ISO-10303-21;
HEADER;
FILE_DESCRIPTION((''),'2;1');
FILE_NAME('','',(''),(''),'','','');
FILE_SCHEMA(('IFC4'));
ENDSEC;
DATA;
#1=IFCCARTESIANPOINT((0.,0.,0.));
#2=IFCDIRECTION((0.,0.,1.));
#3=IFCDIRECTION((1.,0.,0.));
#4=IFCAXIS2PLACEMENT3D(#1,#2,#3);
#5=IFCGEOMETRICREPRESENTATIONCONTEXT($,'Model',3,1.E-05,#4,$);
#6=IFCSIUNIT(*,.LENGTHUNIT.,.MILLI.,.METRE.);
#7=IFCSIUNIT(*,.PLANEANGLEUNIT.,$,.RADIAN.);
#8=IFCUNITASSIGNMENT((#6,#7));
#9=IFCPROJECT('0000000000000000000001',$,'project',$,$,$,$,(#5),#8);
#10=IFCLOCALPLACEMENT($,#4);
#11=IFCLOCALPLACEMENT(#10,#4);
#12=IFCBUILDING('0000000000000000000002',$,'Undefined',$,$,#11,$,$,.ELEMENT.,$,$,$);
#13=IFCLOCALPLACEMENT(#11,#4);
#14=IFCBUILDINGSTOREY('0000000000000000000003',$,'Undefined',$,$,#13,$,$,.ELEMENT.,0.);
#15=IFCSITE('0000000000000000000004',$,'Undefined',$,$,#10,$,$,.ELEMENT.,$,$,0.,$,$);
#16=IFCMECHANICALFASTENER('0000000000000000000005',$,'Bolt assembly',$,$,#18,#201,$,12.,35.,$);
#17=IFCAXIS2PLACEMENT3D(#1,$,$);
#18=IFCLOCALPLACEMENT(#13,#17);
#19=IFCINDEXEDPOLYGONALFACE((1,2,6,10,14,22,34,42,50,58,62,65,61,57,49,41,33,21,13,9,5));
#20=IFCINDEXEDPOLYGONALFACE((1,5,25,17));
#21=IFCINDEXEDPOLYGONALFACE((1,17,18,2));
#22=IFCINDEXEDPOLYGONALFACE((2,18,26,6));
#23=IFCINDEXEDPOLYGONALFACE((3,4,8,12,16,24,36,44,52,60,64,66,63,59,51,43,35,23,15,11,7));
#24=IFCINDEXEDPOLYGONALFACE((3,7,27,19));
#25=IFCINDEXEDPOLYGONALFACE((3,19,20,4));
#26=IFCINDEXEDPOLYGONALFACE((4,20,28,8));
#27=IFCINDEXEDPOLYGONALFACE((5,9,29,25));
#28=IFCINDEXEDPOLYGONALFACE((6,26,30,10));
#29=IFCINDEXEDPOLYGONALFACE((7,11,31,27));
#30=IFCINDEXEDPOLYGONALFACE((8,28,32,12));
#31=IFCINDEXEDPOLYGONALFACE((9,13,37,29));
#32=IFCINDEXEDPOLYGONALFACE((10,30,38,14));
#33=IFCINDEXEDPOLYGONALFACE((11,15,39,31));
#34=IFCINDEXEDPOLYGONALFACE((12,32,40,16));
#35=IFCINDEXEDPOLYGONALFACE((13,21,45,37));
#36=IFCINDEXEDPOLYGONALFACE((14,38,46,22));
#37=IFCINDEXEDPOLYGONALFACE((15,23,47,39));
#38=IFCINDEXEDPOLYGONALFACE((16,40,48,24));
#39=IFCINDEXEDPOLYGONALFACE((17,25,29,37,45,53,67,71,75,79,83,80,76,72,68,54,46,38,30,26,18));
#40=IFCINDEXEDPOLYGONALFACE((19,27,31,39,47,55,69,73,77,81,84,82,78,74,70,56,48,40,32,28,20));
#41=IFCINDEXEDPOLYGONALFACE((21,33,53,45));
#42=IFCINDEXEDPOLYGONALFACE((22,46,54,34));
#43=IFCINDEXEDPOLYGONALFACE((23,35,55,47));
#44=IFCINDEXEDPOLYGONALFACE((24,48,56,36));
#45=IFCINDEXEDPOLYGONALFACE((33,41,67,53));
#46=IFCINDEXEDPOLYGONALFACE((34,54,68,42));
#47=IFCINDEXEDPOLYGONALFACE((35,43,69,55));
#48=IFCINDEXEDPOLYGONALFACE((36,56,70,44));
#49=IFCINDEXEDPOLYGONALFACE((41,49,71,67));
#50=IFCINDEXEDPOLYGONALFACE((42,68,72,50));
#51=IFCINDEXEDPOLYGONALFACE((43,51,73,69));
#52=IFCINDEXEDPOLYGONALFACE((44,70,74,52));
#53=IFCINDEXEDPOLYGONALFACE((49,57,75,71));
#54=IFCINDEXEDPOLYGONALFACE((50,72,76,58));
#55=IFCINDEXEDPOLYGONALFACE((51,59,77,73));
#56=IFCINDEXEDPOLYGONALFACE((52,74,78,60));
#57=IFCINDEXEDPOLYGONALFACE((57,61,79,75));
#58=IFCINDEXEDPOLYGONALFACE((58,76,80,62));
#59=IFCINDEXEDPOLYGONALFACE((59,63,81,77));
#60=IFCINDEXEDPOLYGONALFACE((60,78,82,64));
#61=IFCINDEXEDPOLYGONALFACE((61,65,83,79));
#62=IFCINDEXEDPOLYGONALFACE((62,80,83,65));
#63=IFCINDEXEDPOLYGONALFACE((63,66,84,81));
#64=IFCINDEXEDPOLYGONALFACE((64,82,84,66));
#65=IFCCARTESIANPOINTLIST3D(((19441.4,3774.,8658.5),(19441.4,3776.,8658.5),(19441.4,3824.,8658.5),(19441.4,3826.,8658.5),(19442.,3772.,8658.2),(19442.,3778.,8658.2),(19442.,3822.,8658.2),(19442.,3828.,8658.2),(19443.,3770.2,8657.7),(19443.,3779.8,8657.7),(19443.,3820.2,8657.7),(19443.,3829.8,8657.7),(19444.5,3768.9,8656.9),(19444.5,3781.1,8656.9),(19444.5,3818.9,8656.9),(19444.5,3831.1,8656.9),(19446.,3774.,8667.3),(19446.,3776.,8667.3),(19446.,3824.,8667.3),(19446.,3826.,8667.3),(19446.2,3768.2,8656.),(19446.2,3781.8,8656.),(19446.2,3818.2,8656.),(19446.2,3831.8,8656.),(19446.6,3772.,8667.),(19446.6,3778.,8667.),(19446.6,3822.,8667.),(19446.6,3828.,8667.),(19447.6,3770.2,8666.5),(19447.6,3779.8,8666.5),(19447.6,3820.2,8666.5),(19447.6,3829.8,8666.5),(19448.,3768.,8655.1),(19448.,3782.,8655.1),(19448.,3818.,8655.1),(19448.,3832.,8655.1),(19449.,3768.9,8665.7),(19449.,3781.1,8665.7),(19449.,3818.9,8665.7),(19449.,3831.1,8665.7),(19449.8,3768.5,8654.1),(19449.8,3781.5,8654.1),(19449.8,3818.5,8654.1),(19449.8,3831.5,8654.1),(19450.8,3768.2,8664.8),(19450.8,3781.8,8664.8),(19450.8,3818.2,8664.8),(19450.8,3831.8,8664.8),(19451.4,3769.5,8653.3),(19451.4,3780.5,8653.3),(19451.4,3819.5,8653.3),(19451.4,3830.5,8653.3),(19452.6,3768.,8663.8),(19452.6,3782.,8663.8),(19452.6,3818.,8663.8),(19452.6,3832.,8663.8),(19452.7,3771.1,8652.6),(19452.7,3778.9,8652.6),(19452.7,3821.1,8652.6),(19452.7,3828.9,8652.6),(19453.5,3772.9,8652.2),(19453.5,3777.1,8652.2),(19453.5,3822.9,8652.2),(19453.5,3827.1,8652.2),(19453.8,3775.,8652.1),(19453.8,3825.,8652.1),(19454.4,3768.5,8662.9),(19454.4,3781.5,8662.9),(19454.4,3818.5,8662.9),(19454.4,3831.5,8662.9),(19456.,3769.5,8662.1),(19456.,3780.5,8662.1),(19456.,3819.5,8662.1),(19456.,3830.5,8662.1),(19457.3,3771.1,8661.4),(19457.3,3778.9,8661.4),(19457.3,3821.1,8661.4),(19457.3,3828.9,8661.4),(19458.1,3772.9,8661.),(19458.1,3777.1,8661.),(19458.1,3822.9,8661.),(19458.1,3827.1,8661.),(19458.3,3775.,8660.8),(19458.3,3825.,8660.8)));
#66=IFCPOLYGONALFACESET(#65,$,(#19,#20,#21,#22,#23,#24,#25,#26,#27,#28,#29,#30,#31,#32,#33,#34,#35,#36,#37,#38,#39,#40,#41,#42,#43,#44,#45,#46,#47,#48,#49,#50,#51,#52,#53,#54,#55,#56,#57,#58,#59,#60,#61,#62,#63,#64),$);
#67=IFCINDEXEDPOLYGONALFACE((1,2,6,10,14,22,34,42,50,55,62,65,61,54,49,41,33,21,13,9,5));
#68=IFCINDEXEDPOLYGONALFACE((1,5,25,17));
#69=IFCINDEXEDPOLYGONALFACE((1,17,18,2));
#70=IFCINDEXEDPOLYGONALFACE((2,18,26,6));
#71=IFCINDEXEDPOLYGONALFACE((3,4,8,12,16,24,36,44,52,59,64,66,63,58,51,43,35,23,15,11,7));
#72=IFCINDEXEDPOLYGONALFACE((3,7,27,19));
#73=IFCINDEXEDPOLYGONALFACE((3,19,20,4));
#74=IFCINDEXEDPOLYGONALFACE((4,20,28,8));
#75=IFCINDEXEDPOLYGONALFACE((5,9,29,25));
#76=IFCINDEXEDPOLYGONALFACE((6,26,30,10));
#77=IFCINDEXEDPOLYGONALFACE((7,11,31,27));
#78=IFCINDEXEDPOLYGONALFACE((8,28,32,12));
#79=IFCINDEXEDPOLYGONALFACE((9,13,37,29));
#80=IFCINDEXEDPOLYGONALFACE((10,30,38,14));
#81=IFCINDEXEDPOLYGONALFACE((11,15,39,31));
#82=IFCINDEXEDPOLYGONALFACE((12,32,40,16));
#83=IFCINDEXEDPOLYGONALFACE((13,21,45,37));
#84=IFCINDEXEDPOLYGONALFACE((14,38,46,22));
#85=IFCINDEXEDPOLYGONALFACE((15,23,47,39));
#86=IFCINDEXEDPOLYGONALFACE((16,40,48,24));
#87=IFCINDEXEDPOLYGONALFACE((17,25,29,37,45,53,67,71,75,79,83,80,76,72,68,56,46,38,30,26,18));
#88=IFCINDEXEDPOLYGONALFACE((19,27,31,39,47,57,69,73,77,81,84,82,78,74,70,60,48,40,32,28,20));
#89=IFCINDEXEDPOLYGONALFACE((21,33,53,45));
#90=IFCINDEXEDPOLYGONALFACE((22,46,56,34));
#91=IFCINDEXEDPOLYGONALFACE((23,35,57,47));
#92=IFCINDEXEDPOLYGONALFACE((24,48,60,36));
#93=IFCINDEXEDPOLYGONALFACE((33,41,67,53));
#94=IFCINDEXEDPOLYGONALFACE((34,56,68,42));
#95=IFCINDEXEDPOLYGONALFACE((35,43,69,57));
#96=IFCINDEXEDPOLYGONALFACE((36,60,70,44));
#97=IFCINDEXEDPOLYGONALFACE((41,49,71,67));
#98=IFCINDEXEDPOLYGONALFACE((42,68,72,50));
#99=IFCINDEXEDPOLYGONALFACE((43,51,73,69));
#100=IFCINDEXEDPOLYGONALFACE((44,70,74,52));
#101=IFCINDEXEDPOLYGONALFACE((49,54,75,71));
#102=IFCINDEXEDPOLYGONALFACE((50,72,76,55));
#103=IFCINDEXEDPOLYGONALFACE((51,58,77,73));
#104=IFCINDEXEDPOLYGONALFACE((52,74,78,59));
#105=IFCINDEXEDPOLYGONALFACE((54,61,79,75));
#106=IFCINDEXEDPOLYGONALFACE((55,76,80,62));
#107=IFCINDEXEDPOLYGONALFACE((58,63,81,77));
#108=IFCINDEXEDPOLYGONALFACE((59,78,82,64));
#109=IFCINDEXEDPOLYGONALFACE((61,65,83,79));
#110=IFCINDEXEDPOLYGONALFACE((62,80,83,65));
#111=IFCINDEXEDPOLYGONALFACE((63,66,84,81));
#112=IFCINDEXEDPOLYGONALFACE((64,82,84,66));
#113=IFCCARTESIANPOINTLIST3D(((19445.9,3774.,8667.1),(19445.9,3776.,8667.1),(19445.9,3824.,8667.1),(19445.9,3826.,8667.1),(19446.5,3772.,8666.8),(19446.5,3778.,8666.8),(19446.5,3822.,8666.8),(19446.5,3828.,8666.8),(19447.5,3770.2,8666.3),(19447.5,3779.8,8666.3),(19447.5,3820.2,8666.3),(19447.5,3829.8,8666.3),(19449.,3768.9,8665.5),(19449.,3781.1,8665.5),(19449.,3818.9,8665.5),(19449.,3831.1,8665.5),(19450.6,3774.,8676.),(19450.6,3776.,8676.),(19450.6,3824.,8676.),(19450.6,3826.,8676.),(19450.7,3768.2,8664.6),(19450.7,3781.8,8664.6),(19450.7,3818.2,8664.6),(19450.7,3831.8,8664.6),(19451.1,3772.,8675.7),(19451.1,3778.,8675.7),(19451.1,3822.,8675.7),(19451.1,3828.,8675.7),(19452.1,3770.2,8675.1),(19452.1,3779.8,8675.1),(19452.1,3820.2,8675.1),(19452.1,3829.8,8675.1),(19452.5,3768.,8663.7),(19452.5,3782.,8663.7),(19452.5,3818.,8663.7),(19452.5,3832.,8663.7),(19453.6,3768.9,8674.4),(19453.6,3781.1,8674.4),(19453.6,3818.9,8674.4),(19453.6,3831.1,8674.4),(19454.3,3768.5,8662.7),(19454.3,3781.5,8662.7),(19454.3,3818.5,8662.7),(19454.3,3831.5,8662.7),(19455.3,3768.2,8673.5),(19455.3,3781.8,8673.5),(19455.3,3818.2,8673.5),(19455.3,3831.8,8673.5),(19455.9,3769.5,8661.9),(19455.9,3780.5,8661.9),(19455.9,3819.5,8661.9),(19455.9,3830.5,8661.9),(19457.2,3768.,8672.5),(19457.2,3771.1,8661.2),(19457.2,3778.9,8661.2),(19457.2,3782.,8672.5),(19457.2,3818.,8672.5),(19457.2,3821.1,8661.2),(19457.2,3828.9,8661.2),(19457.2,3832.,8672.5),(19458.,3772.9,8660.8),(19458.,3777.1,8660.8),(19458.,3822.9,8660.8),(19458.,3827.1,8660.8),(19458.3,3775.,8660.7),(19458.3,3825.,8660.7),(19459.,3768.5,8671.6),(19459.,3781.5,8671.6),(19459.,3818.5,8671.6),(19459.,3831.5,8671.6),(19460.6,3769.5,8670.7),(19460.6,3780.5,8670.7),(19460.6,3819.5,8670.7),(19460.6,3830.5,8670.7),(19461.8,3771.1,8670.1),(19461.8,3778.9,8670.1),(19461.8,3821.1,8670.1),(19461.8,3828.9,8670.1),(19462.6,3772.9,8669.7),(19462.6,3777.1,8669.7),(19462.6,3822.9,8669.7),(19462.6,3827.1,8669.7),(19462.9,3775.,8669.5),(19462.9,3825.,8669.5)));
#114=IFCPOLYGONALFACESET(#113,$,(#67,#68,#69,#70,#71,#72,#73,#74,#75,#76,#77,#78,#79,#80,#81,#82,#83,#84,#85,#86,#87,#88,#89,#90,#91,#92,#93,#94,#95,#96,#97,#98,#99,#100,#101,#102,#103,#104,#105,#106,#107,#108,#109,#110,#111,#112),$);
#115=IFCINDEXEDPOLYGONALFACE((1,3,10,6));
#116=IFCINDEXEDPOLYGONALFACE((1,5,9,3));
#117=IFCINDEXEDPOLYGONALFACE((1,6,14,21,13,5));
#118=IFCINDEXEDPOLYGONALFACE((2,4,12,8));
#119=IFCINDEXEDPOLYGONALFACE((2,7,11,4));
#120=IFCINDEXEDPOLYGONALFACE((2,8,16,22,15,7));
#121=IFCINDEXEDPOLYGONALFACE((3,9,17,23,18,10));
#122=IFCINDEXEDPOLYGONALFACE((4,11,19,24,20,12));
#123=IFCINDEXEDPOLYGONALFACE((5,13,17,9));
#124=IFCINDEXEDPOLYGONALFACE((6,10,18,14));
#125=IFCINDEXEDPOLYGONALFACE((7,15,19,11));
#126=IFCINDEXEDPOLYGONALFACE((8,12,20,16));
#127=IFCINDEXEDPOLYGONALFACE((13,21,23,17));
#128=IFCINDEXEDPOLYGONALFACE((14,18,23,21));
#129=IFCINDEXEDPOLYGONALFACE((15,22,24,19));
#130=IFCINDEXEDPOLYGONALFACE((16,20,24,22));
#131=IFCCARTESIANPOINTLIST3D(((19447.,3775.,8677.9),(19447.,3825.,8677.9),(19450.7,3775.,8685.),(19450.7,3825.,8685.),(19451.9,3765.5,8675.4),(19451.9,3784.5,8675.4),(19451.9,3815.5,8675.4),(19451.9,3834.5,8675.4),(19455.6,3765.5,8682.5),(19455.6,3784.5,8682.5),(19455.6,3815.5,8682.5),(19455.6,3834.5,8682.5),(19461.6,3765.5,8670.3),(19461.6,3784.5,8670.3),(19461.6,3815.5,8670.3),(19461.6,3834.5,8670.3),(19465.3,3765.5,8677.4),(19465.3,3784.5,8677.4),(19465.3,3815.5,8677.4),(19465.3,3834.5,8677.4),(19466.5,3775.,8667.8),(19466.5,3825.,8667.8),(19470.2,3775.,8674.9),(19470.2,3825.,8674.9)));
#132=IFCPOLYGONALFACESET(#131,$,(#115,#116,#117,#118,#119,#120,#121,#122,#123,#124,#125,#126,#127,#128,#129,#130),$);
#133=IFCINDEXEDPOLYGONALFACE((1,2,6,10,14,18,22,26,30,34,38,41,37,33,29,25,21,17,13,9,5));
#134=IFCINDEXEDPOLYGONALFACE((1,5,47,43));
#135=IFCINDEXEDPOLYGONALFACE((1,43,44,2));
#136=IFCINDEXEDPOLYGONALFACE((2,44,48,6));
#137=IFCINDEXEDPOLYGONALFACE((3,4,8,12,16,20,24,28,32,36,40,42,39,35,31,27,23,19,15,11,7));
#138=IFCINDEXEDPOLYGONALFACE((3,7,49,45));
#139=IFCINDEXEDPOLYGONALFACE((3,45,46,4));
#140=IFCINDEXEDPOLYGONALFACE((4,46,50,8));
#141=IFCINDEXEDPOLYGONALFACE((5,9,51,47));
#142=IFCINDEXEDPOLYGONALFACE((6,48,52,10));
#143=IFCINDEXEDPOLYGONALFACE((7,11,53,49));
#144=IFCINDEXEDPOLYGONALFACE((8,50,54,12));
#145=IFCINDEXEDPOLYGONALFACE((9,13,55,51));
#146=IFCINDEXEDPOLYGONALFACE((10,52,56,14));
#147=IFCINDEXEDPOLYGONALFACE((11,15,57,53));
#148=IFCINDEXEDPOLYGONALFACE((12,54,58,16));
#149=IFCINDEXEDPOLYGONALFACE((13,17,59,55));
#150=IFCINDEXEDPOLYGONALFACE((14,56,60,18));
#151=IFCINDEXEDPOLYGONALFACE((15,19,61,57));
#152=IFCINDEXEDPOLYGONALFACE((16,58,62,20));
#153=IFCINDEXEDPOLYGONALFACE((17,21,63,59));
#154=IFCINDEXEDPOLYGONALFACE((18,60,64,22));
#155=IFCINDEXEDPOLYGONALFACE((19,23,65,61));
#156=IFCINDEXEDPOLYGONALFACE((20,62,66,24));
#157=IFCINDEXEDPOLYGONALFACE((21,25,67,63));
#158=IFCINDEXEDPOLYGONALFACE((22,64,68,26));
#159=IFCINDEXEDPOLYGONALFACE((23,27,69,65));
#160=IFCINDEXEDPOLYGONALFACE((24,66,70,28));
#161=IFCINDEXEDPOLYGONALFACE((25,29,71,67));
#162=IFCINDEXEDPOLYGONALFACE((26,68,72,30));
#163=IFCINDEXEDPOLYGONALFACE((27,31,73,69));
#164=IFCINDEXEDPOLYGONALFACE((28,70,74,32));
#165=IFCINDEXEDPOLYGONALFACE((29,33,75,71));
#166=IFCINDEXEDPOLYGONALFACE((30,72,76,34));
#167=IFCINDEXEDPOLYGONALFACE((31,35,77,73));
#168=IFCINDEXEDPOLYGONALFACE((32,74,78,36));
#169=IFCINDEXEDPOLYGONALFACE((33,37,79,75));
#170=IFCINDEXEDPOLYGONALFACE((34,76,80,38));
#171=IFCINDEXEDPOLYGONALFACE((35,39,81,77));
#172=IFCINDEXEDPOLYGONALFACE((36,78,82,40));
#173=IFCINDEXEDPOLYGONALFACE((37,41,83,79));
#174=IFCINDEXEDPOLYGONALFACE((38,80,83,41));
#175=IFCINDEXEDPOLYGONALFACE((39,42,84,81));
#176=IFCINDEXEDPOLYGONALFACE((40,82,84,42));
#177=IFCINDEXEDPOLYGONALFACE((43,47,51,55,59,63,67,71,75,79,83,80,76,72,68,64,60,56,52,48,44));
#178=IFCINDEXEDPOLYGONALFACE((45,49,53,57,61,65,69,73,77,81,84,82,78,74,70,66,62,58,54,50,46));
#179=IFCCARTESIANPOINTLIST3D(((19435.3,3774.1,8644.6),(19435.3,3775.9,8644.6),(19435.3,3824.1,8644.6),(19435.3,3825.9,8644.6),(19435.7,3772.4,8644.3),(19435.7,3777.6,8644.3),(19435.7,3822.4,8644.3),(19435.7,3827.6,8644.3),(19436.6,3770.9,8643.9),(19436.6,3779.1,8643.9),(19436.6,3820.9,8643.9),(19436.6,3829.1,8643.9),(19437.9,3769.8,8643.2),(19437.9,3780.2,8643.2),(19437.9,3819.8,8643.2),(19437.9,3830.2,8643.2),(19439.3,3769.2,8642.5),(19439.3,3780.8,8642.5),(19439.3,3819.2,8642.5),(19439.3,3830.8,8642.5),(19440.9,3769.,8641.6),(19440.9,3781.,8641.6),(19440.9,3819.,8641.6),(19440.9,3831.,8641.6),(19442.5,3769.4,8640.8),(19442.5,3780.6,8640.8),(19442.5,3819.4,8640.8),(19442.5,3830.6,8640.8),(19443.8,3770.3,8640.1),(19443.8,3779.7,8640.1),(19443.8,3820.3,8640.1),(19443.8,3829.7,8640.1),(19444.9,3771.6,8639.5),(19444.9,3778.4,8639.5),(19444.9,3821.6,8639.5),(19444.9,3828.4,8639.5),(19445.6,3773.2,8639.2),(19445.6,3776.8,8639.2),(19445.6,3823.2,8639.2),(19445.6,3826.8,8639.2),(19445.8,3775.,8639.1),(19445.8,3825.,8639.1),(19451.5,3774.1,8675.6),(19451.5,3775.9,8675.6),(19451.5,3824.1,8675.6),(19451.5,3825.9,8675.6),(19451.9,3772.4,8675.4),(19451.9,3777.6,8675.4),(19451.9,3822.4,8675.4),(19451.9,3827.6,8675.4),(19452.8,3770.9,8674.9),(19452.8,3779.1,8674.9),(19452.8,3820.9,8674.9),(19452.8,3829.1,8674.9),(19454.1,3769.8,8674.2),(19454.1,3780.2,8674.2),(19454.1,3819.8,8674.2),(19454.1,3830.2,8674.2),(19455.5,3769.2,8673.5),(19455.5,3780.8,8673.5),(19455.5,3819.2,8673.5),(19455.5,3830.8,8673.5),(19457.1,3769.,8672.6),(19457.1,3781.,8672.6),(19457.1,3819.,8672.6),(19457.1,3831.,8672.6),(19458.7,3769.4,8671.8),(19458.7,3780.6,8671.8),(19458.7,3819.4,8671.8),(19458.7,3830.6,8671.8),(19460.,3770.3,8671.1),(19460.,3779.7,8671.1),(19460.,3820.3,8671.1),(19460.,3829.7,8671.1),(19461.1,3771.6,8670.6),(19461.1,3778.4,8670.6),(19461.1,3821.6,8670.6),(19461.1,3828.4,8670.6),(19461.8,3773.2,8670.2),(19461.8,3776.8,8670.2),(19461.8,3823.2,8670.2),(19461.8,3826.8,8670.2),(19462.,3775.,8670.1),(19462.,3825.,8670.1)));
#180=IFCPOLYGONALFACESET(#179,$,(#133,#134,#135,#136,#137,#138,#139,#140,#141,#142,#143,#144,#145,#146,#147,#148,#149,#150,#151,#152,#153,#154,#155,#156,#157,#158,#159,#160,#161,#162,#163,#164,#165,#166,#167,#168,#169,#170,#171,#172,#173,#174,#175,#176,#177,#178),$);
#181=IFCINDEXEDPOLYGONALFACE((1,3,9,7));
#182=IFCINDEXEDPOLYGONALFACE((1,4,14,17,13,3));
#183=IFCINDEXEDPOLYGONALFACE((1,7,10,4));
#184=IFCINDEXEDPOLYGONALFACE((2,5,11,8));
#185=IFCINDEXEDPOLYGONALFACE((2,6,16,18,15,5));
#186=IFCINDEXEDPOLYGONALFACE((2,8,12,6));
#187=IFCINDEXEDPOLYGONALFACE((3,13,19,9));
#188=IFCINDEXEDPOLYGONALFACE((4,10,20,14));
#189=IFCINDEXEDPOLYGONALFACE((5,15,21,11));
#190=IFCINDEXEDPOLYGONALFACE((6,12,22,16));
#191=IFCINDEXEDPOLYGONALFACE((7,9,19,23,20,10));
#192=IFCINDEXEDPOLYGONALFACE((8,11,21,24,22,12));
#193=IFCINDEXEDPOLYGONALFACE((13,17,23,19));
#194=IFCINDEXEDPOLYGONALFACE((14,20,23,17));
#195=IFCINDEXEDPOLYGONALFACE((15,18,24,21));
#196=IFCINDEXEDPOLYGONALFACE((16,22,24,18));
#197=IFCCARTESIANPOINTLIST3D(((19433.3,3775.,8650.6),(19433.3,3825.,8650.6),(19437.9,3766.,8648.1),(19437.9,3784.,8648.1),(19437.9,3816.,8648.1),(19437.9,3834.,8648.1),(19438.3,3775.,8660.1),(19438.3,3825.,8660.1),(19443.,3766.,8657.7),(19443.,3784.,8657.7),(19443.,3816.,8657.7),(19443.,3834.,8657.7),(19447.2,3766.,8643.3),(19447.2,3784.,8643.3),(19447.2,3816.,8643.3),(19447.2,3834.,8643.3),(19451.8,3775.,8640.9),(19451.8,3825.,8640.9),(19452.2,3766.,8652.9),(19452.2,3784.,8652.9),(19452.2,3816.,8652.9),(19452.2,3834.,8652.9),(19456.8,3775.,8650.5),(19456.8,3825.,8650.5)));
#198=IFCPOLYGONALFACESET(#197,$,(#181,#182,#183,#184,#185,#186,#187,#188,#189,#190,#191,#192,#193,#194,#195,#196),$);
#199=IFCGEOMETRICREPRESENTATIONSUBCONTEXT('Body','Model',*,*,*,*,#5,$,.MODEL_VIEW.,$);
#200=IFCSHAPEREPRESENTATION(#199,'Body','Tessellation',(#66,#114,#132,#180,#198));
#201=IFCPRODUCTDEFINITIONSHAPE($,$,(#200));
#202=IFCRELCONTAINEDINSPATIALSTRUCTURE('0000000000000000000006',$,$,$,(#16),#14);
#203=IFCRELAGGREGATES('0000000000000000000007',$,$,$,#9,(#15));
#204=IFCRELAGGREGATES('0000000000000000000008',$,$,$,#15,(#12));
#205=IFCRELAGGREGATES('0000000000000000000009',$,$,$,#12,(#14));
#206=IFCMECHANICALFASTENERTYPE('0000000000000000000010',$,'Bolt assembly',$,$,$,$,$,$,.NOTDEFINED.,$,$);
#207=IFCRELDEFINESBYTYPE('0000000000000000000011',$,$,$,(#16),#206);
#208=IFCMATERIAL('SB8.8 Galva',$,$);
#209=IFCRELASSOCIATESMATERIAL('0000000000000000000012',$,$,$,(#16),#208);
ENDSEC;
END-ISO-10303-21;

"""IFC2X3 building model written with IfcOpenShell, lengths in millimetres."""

from ifc_helpers import new_model, si_unit, frame, origin_with_axes, origin_2d_with_axis, place, context, subcontext, project, spatial, polyline, circle, outline, extrude, source, transform, mapped, material, type_object, element, save


model = new_model("IFC2X3")

# Units and contexts
model_context = context("Model", 3, precision=1e-05, world=origin_with_axes())
body_context = subcontext(model_context, "Body", "Model", "MODEL_VIEW")
ifc_project = project(units=[si_unit("LENGTHUNIT", "METRE", prefix="MILLI"), si_unit("PLANEANGLEUNIT", "RADIAN")], contexts=[model_context])

# Site, building, storey
site_placement = place(None, origin_with_axes())
site = spatial("IfcSite", under=ifc_project, at=site_placement, Name="Undefined", CompositionType="ELEMENT", RefElevation=0.0)
building_placement = place(site_placement, origin_with_axes())
building = spatial("IfcBuilding", under=site, at=building_placement, Name="Undefined", CompositionType="ELEMENT")
storey_placement = place(building_placement, origin_with_axes())
storey = spatial("IfcBuildingStorey", under=building, at=storey_placement, Name="Undefined", CompositionType="ELEMENT", Elevation=0.0)

# Mechanical fastener
mechanical_fastener_type = type_object("IfcMechanicalFastenerType", Name="Bolt assembly")
ifc_material_1 = material(Name="SB8.8 Galva")
shared_shape_1 = source(origin_with_axes(), body_context, "Body", "SweptSolid", [
    extrude(circle(Radius=7.0, at=origin_2d_with_axis()), frame((0.0, -0.1, 0.0), z_axis=(0.0, 1.0, 0.0), x_axis=(1.0, 0.0, 0.0)), (0.0, 0.0, 1.0), 9.9),
    extrude(circle(Radius=7.0, at=origin_2d_with_axis()), frame((0.0, -9.9, 0.0), z_axis=(0.0, 1.0, 0.0), x_axis=(1.0, 0.0, 0.0)), (0.0, 0.0, 1.0), 10.0),
    extrude(outline(polyline([(11.0, 0.0), (5.5, 9.5), (-5.5, 9.5), (-11.0, 0.0), (-5.5, -9.5), (5.5, -9.5), (11.0, 0.0)])), frame((0.0, -18.0, 0.0), z_axis=(0.0, 1.0, 0.0), x_axis=(1.0, 0.0, 0.0)), (0.0, 0.0, 1.0), 8.0),
    extrude(circle(Radius=6.0, at=origin_2d_with_axis()), frame((0.0, -10.0, 0.0), z_axis=(0.0, 1.0, 0.0), x_axis=(1.0, 0.0, 0.0)), (0.0, 0.0, 1.0), 35.0),
    extrude(outline(polyline([(10.4, 0.0), (5.2, 9.0), (-5.2, 9.0), (-10.4, 0.0), (-5.2, -9.0), (5.2, -9.0), (10.4, 0.0)])), frame((0.0, 9.8, 0.0), z_axis=(0.0, 1.0, 0.0), x_axis=(1.0, 0.0, 0.0)), (0.0, 0.0, 1.0), 10.8),
])
for number, where, z_axis, x_axis, name in (
    (1, (19452.1, 3800.0, 8664.0), (0.0, 1.0, 0.0), (0.886082, 0.0, -0.463529), "Bolt assembly"),
):
    element("IfcMechanicalFastener", number, at=place(storey_placement, frame(where, z_axis=z_axis, x_axis=x_axis)), inside=storey, type_object=mechanical_fastener_type, material=ifc_material_1, Name=name, NominalDiameter=12.0, NominalLength=35.0, context=body_context, shape_type="MappedRepresentation", body=[
        mapped(shared_shape_1, transform((0.0, 0.0, -25.0))),
        mapped(shared_shape_1, transform((0.0, 0.0, 25.0))),
    ])

save(model, "model.ifc")
